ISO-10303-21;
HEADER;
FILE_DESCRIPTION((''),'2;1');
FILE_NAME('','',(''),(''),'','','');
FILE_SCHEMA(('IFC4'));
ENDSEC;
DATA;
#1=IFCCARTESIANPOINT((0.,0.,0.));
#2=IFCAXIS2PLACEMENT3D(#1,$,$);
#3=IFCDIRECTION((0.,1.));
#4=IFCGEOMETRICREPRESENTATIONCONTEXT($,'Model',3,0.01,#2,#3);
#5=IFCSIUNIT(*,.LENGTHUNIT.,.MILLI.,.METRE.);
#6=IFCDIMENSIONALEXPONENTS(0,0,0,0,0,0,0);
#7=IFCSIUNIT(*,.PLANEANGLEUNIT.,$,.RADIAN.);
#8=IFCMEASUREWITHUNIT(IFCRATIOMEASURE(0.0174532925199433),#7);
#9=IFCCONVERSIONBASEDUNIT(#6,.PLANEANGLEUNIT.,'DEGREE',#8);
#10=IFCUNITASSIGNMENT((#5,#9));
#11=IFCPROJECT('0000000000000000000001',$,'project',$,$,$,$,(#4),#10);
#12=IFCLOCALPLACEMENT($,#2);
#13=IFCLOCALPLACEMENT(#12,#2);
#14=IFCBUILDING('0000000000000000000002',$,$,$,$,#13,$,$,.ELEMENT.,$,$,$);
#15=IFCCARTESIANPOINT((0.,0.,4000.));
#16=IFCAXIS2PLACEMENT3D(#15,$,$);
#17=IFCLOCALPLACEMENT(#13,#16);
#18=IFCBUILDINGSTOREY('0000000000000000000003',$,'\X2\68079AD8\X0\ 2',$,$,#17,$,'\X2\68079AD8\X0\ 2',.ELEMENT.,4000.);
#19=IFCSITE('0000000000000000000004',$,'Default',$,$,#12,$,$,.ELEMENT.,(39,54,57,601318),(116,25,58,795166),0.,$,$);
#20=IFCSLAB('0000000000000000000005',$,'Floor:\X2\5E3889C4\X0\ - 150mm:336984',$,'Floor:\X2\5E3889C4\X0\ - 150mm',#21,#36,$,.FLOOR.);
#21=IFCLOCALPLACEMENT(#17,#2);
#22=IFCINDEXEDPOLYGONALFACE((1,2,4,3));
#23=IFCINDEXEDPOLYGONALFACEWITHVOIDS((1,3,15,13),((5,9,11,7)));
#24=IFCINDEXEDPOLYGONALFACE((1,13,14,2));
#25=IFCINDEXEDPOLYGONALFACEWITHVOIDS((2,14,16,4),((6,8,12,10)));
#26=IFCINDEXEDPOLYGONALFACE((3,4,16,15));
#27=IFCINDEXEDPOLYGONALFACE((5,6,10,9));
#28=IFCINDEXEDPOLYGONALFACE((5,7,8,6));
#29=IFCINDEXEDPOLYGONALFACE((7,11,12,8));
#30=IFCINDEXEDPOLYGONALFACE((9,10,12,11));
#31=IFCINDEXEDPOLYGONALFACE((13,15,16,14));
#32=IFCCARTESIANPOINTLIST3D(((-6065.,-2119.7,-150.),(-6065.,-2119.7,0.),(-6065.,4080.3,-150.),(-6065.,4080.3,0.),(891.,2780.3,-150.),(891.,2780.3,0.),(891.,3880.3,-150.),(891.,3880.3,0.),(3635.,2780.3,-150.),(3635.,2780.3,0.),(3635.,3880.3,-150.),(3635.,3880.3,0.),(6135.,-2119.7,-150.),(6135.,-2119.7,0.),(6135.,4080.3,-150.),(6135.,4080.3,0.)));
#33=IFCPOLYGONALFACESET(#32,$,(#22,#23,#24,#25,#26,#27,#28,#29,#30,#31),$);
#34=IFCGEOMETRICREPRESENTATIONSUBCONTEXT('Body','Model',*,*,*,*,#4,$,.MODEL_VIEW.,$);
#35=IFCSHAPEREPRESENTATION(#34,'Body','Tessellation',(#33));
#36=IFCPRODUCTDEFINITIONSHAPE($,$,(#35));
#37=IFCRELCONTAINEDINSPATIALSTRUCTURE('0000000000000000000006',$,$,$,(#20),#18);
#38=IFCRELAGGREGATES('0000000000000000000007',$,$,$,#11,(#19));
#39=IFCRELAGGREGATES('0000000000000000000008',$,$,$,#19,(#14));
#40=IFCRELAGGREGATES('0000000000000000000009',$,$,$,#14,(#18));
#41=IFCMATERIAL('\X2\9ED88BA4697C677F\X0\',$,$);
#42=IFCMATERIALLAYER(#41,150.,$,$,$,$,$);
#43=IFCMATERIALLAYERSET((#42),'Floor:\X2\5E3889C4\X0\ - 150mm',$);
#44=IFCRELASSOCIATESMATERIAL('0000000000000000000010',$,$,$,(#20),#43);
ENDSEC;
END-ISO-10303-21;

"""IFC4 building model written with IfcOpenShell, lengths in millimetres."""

from ifc_helpers import new_model, entity, si_unit, converted_unit, direction, frame, frame_2d, origin, origin_2d_with_axis, place, context, subcontext, project, spatial, rectangle, extrude, material, layer, layer_set, layer_usage, element, save


model = new_model("IFC4")

# Units and contexts
model_context = context("Model", 3, precision=0.01, world=origin(), true_north=direction((0.0, 1.0)))
body_context = subcontext(model_context, "Body", "Model", "MODEL_VIEW")
ifc_project = project(units=[si_unit("LENGTHUNIT", "METRE", prefix="MILLI"), converted_unit("PLANEANGLEUNIT", "DEGREE", entity("IfcRatioMeasure", 0.0174532925199433), si_unit("PLANEANGLEUNIT", "RADIAN"), dimensions=[0, 0, 0, 0, 0, 0, 0])], contexts=[model_context])

# Site, building, storey
site_placement = place(None, origin())
site = spatial("IfcSite", under=ifc_project, at=site_placement, Name="Default", CompositionType="ELEMENT", RefLatitude=(39, 54, 57, 601318), RefLongitude=(116, 25, 58, 795166), RefElevation=0.0)
building_placement = place(site_placement, origin())
building = spatial("IfcBuilding", under=site, at=building_placement, CompositionType="ELEMENT")
storey_placement = place(building_placement, frame((0.0, 0.0, 4000.0)))
storey = spatial("IfcBuildingStorey", under=building, at=storey_placement, Name="标高 2", LongName="标高 2", CompositionType="ELEMENT", Elevation=4000.0)

# Slab, opening
ifc_material = material(Name="默认楼板")
ifc_layer = layer(ifc_material, 150.0)
ifc_layer_set = layer_set([ifc_layer], Name="Floor:常规 - 150mm")
ifc_layer_usage = layer_usage(ifc_layer_set, "AXIS3", "POSITIVE", 0.0)
slab_placement = place(storey_placement, frame((-6065.0, -2119.7, -150.0)))
slab = element("IfcSlab", 1, at=slab_placement, inside=storey, material=ifc_layer_usage, Name="Floor:常规 - 150mm:336984", ObjectType="Floor:常规 - 150mm", PredefinedType="FLOOR", context=body_context, shape_type="SweptSolid", body=[
    extrude(rectangle(XDim=6200.0, YDim=12200.0, at=frame_2d((0.0, 0.0), x_axis=(0.0, -1.0))), frame((6100.0, 3100.0, 150.0), z_axis=(0.0, 0.0, -1.0), x_axis=(-1.0, 0.0, 0.0)), (0.0, 0.0, 1.0), 150.0),
])
opening_placement = place(slab_placement, frame((8328.0, 5450.0, 150.0)))
element("IfcOpeningElement", 2, at=opening_placement, cuts=slab, ObjectType="Opening", context=body_context, shape_type="SweptSolid", body=[
    extrude(rectangle(XDim=2744.0, YDim=1100.0, at=origin_2d_with_axis()), frame((0.0, 0.0, 0.0), z_axis=(0.0, 0.0, -1.0), x_axis=(1.0, 0.0, 0.0)), (0.0, 0.0, 1.0), 150.0),
])

save(model, "model.ifc")
